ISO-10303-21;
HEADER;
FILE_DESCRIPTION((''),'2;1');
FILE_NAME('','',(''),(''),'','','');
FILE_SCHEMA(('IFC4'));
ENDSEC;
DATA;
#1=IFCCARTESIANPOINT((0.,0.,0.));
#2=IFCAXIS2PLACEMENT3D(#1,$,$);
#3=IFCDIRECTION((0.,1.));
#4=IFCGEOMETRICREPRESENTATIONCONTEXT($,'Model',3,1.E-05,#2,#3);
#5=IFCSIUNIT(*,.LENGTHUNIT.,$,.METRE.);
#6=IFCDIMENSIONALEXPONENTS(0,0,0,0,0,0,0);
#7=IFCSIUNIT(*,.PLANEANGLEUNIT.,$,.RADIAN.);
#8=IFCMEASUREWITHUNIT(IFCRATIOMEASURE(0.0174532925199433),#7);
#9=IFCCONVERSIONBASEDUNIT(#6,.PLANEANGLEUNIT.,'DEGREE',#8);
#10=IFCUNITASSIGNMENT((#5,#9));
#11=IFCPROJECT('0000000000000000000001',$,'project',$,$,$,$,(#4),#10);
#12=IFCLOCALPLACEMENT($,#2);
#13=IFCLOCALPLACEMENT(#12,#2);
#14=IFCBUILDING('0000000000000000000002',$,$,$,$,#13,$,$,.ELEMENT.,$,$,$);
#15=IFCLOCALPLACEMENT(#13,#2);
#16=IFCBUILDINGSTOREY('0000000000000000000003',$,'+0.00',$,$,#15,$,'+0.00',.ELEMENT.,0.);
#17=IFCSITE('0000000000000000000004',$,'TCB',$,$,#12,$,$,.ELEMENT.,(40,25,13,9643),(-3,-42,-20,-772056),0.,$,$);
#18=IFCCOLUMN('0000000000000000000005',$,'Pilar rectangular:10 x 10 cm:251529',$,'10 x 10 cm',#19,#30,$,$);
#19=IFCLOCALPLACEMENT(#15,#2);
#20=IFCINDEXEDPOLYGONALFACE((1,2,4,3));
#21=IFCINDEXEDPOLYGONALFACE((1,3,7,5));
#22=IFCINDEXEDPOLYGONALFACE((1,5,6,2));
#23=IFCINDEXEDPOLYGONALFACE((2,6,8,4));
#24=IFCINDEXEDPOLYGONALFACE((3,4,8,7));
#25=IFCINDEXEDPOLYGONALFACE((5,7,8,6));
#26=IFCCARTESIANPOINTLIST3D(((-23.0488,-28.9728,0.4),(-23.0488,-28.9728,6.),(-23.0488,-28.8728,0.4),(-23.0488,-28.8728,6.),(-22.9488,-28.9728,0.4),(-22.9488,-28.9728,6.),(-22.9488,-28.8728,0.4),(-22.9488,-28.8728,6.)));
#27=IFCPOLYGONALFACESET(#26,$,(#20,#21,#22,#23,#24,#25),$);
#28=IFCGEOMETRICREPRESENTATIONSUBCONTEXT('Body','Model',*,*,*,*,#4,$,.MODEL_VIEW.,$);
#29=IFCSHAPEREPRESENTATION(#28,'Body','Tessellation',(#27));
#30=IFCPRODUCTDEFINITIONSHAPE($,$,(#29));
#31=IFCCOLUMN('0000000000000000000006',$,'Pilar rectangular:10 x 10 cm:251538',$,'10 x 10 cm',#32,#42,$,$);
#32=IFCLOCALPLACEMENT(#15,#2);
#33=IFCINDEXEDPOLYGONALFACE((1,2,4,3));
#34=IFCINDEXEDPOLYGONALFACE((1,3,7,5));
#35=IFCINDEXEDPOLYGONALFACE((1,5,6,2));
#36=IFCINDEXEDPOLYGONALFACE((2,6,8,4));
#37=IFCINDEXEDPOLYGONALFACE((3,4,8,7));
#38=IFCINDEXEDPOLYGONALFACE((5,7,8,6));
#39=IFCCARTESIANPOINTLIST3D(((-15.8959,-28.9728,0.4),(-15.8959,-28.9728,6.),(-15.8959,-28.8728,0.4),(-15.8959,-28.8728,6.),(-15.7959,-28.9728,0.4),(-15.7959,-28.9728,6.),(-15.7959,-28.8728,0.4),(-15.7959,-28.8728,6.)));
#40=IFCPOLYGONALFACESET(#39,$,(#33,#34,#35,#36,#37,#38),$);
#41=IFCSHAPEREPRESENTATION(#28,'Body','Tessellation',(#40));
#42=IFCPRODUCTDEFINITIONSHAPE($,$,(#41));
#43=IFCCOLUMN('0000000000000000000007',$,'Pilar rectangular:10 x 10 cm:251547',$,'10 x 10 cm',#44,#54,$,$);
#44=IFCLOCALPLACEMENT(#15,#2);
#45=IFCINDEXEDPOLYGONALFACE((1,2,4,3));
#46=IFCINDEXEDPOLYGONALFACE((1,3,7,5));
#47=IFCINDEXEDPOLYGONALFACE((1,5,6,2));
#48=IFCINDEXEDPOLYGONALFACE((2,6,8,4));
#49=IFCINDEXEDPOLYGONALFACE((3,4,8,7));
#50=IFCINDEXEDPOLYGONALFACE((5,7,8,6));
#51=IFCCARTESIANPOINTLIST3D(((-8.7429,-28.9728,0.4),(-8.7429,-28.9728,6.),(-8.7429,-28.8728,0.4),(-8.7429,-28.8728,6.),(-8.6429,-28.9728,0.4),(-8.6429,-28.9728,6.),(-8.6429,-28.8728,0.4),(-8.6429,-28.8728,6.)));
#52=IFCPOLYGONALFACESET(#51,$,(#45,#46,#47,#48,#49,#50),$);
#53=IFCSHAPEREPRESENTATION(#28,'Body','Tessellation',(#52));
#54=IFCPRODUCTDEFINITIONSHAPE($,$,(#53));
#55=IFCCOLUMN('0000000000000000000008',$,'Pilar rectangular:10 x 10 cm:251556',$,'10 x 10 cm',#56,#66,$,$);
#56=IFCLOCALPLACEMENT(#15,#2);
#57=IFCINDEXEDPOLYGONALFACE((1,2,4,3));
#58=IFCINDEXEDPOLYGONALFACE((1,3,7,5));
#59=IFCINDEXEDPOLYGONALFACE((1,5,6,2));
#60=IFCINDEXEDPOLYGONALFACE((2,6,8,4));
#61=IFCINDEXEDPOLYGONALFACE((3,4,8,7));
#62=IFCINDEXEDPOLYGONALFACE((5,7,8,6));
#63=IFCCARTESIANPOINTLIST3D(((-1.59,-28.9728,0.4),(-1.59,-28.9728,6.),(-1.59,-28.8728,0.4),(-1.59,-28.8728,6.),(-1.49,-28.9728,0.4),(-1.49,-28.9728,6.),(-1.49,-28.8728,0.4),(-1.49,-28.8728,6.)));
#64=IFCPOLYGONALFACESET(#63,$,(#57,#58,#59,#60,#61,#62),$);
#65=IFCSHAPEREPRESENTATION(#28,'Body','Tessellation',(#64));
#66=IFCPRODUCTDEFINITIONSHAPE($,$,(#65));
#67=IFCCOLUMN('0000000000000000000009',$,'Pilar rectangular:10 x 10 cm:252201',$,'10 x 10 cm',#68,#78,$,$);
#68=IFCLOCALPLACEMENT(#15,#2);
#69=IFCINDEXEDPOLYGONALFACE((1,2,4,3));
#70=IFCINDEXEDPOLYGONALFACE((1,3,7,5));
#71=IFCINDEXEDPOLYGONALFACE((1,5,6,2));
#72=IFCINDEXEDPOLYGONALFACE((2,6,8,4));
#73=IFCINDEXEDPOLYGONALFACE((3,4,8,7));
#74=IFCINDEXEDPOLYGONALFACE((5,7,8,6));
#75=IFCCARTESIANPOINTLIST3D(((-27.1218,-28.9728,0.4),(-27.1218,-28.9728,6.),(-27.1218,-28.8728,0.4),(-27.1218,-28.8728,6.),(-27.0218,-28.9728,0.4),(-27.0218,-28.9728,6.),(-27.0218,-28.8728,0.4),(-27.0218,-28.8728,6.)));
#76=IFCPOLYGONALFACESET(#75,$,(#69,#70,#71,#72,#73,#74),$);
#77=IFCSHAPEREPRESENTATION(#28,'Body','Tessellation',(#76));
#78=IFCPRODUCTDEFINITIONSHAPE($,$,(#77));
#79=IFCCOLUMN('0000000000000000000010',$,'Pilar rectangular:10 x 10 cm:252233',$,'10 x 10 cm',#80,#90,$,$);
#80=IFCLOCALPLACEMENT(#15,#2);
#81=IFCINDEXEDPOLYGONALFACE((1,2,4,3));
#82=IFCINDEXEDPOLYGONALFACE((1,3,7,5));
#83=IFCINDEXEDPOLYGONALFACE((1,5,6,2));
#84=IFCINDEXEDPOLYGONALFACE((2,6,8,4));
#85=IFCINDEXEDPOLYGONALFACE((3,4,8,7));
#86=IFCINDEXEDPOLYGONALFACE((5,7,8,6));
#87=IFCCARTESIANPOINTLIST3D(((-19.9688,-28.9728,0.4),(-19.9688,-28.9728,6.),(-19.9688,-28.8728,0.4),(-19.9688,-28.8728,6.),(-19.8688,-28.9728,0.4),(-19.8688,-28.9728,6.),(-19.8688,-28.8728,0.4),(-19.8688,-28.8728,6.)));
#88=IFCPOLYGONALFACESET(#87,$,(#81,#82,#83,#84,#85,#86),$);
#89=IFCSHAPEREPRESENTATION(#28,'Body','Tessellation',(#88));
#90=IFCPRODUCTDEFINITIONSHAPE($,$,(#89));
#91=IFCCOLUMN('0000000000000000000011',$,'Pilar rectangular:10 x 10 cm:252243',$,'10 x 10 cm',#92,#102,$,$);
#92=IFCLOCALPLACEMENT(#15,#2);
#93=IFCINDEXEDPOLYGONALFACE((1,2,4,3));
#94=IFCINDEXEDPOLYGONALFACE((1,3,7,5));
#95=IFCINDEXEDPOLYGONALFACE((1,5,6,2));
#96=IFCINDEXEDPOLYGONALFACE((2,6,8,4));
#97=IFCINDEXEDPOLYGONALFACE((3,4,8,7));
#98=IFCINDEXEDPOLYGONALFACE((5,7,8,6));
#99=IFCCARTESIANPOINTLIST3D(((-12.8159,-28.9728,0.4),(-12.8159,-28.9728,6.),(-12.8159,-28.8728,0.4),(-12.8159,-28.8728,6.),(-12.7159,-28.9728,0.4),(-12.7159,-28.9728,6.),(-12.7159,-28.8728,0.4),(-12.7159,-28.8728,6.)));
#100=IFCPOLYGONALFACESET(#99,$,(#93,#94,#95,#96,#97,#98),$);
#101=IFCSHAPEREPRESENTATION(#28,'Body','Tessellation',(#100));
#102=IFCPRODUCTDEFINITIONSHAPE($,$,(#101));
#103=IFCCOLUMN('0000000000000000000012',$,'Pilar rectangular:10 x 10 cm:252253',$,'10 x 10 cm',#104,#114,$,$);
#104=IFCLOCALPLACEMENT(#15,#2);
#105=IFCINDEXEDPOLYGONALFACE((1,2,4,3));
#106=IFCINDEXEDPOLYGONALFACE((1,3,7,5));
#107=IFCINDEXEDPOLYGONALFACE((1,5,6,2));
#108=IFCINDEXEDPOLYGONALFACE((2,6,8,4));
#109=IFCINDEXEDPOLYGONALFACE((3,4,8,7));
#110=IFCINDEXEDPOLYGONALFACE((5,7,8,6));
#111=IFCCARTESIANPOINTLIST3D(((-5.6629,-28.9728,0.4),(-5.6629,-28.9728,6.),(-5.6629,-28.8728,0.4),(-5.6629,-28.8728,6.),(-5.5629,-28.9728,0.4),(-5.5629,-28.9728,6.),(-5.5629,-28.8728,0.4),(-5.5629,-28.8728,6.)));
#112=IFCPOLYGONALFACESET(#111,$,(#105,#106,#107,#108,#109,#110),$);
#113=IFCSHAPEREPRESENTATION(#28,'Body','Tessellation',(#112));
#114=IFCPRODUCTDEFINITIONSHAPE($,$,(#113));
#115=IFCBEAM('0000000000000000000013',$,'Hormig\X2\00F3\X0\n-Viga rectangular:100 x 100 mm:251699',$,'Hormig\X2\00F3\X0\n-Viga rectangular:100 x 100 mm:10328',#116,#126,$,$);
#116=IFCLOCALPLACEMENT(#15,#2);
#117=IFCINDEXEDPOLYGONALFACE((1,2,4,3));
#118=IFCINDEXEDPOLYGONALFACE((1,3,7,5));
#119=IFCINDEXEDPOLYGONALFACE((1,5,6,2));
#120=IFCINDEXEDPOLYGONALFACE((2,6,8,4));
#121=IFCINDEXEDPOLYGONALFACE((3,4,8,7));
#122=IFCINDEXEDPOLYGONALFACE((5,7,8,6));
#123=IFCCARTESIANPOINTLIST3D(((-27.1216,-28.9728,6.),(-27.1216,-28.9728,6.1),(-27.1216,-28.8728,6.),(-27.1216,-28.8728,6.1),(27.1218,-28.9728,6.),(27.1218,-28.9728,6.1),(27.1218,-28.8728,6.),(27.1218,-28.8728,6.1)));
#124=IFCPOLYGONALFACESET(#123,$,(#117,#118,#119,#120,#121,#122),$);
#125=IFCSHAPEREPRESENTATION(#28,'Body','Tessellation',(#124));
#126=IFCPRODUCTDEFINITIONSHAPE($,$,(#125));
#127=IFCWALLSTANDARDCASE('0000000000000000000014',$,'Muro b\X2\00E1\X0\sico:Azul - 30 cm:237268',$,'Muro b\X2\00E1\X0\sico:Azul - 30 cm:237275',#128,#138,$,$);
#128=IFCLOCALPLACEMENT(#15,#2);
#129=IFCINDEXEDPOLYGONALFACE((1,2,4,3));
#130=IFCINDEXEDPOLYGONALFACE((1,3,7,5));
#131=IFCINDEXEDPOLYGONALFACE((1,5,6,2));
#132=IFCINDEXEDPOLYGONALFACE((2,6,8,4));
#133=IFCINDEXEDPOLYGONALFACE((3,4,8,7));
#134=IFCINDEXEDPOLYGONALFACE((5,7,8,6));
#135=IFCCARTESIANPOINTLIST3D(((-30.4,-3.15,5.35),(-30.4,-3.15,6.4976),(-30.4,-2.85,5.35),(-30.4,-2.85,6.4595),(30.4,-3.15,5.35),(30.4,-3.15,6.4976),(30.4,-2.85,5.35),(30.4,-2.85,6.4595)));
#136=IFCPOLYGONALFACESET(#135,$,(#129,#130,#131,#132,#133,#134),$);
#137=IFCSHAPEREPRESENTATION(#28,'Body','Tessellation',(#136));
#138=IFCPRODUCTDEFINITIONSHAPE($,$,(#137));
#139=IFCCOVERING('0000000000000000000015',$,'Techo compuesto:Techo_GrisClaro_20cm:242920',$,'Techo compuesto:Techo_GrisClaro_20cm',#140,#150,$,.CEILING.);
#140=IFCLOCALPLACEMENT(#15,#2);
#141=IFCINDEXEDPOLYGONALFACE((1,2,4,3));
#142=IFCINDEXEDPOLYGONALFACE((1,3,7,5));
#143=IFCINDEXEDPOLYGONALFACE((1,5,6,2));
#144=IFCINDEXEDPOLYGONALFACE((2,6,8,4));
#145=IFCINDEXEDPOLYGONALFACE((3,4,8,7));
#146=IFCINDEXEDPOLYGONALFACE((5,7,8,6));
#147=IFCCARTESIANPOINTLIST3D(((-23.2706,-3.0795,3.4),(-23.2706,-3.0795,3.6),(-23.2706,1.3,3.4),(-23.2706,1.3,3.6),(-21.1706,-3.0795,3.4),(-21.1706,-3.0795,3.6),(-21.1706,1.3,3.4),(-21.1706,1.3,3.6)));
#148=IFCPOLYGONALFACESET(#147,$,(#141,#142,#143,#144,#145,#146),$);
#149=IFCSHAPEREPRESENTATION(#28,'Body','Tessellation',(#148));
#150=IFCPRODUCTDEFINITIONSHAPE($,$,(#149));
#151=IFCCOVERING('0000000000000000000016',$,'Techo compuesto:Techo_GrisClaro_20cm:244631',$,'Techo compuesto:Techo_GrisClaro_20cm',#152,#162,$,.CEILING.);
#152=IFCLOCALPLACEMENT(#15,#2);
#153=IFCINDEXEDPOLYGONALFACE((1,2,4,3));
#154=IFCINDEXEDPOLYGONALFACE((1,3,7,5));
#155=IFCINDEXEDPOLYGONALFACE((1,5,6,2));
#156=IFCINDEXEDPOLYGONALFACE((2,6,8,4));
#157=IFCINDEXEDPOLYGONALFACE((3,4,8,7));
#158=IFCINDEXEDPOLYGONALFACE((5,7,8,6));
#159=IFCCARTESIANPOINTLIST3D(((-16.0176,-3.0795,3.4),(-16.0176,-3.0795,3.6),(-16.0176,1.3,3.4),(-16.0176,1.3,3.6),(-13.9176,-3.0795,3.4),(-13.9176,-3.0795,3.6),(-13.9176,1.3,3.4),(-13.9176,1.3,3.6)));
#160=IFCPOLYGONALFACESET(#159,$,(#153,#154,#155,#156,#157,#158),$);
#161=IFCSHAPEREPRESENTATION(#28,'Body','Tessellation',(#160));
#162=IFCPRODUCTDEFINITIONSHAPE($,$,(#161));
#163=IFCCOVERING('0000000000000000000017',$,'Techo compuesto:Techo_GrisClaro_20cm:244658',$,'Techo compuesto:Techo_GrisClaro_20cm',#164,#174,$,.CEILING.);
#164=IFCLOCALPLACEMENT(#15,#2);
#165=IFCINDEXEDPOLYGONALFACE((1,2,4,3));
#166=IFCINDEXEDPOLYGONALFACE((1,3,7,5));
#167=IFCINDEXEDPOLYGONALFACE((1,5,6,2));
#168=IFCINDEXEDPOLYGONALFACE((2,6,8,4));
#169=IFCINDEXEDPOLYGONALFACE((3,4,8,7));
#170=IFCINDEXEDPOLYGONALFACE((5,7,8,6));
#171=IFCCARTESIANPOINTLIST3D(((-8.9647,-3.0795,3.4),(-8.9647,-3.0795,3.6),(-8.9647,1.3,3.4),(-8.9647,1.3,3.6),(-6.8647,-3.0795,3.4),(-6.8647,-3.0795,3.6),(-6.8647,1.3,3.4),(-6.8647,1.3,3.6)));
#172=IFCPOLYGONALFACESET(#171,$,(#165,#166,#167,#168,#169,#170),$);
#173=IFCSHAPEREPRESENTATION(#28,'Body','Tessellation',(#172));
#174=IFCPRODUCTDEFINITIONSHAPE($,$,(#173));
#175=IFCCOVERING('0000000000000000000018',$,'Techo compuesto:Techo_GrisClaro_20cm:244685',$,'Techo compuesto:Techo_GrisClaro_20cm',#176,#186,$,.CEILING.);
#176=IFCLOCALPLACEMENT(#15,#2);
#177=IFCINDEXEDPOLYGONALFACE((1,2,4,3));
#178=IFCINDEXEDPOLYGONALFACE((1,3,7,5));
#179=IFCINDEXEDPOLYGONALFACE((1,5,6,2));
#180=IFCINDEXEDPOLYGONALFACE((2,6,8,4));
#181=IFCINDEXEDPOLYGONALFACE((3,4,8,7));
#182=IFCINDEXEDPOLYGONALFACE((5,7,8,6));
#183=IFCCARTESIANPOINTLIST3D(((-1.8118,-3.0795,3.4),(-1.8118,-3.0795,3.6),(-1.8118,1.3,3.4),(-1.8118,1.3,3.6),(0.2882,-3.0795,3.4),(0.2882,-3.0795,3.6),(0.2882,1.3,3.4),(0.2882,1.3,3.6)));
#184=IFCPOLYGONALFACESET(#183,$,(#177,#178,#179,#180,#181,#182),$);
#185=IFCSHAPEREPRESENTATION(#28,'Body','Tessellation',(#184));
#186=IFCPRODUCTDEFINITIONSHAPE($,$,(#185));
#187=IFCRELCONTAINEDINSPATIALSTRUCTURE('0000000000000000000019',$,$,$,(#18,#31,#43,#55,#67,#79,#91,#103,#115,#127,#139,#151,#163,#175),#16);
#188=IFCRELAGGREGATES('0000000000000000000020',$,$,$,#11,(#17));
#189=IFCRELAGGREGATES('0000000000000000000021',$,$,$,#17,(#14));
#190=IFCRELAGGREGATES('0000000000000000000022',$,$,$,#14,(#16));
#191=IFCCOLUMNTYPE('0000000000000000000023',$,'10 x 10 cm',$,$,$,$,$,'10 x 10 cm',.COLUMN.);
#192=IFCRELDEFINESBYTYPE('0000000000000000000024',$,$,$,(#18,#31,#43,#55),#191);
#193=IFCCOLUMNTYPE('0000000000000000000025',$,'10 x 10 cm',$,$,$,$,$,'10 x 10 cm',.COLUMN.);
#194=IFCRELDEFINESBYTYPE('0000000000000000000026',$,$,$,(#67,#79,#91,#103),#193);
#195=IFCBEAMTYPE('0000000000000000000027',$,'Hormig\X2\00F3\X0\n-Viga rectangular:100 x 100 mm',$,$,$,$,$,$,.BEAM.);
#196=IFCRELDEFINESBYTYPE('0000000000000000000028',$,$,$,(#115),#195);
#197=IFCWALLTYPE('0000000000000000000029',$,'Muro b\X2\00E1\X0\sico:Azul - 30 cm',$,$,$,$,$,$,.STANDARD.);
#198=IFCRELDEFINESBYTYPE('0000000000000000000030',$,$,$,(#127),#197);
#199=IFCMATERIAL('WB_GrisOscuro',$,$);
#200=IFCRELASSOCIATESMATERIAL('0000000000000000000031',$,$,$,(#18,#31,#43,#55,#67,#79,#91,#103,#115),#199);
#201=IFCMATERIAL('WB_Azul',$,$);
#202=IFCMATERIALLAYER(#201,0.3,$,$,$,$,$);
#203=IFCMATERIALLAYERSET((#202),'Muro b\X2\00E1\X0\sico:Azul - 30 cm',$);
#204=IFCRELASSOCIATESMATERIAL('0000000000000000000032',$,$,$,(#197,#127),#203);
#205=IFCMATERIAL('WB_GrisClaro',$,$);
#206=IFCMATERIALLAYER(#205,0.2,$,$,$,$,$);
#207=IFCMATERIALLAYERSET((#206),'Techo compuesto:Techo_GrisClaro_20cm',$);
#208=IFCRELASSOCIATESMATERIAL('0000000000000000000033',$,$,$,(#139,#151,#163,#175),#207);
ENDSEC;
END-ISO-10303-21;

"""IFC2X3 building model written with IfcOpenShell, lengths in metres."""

from ifc_helpers import new_model, entity, si_unit, converted_unit, direction, frame, frame_2d, origin, origin_2d_with_axis, place, context, subcontext, project, spatial, polyline, rectangle, extrude, clip, bounded_halfspace, source, transform, mapped, material, layer, layer_set, layer_usage, type_object, type_shapes, element, save


model = new_model("IFC2X3")

# Units and contexts
model_context = context("Model", 3, precision=1e-05, world=origin(), true_north=direction((0.0, 1.0)))
body_context = subcontext(model_context, "Body", "Model", "MODEL_VIEW")
ifc_project = project(units=[si_unit("LENGTHUNIT", "METRE"), converted_unit("PLANEANGLEUNIT", "DEGREE", entity("IfcRatioMeasure", 0.0174532925199433), si_unit("PLANEANGLEUNIT", "RADIAN"), dimensions=[0, 0, 0, 0, 0, 0, 0])], contexts=[model_context])

# Site, building, storey
site_placement = place(None, origin())
site = spatial("IfcSite", under=ifc_project, at=site_placement, Name="TCB", CompositionType="ELEMENT", RefLatitude=(40, 25, 13, 9643), RefLongitude=(-3, -42, -20, -772056), RefElevation=0.0)
building_placement = place(site_placement, origin())
building = spatial("IfcBuilding", under=site, at=building_placement, CompositionType="ELEMENT")
storey_placement = place(building_placement, origin())
storey = spatial("IfcBuildingStorey", under=building, at=storey_placement, Name="+0.00", LongName="+0.00", CompositionType="ELEMENT", Elevation=0.0)

# Columns
ifc_material_1 = material(Name="WB_GrisOscuro")
column_type_1 = type_object("IfcColumnType", Name="10 x 10 cm", ElementType="10 x 10 cm", PredefinedType="COLUMN")
shared_shape_1 = source(origin(), body_context, "Body", "SweptSolid", [
    extrude(rectangle(XDim=0.1, YDim=0.1, at=origin_2d_with_axis()), frame((0.0, 0.0, 0.4), z_axis=(0.0, 0.0, 1.0), x_axis=(0.0, -1.0, 0.0)), (0.0, 0.0, 1.0), 5.6),
])
type_shapes(column_type_1, [shared_shape_1])
for number, where, name in (
    (1, (-22.9988, -28.9228, 0.0), "Pilar rectangular:10 x 10 cm:251529"),
    (2, (-15.8459, -28.9228, 0.0), "Pilar rectangular:10 x 10 cm:251538"),
    (3, (-8.6929, -28.9228, 0.0), "Pilar rectangular:10 x 10 cm:251547"),
    (4, (-1.54, -28.9228, 0.0), "Pilar rectangular:10 x 10 cm:251556"),
):
    element("IfcColumn", number, at=place(storey_placement, frame(where)), inside=storey, type_object=column_type_1, material=ifc_material_1, Name=name, ObjectType="10 x 10 cm", context=body_context, shape_type="MappedRepresentation", body=[
        mapped(shared_shape_1, transform((0.0, 0.0, 0.0), scale=1.0)),
    ])
column_type_2 = type_object("IfcColumnType", Name="10 x 10 cm", ElementType="10 x 10 cm", PredefinedType="COLUMN")
shared_shape_2 = source(origin(), body_context, "Body", "SweptSolid", [
    extrude(rectangle(XDim=0.1, YDim=0.1, at=origin_2d_with_axis()), frame((0.0, 0.0, 0.4), z_axis=(0.0, 0.0, 1.0), x_axis=(0.0, -1.0, 0.0)), (0.0, 0.0, 1.0), 5.6),
])
type_shapes(column_type_2, [shared_shape_2])
for number, where, z_axis, x_axis, name in (
    (5, (-27.0718, -28.9228, 0.0), (0.0, 0.0, 1.0), (-1.0, 0.0, 0.0), "Pilar rectangular:10 x 10 cm:252201"),
    (6, (-19.9188, -28.9228, 0.0), (0.0, 0.0, 1.0), (-1.0, 0.0, 0.0), "Pilar rectangular:10 x 10 cm:252233"),
    (7, (-12.7659, -28.9228, 0.0), (0.0, 0.0, 1.0), (-1.0, 0.0, 0.0), "Pilar rectangular:10 x 10 cm:252243"),
    (8, (-5.6129, -28.9228, 0.0), (0.0, 0.0, 1.0), (-1.0, 0.0, 0.0), "Pilar rectangular:10 x 10 cm:252253"),
):
    element("IfcColumn", number, at=place(storey_placement, frame(where, z_axis=z_axis, x_axis=x_axis)), inside=storey, type_object=column_type_2, material=ifc_material_1, Name=name, ObjectType="10 x 10 cm", context=body_context, shape_type="MappedRepresentation", body=[
        mapped(shared_shape_2, transform((0.0, 0.0, 0.0), scale=1.0)),
    ])

# Beam
beam_type = type_object("IfcBeamType", Name="Hormigón-Viga rectangular:100 x 100 mm", PredefinedType="BEAM")
beam_placement = place(storey_placement, frame((-27.1093, -28.9228, 6.0)))
element("IfcBeam", 9, at=beam_placement, inside=storey, type_object=beam_type, material=ifc_material_1, Name="Hormigón-Viga rectangular:100 x 100 mm:251699", ObjectType="Hormigón-Viga rectangular:100 x 100 mm:10328", context=body_context, shape_type="SweptSolid", body=[
    extrude(rectangle(XDim=0.1, YDim=0.1, at=frame_2d((0.0, 0.0), x_axis=(1.0, 0.0))), frame((-0.0123, 0.0, 0.05), z_axis=(1.0, 0.0, 0.0), x_axis=(0.0, 0.0, -1.0)), (0.0, 0.0, 1.0), 54.2434),
])

# Wall
ifc_material_2 = material(Name="WB_Azul")
ifc_layer_1 = layer(ifc_material_2, 0.3)
ifc_layer_set_1 = layer_set([ifc_layer_1], Name="Muro básico:Azul - 30 cm")
ifc_layer_usage_1 = layer_usage(ifc_layer_set_1, "AXIS2", "POSITIVE", -0.15)
wall_type = type_object("IfcWallType", Name="Muro básico:Azul - 30 cm", PredefinedType="STANDARD", material=ifc_layer_set_1)
wall_placement = place(storey_placement, frame((-30.4, -3.0, 5.35)))
element("IfcWallStandardCase", 10, at=wall_placement, inside=storey, type_object=wall_type, material=ifc_layer_usage_1, Name="Muro básico:Azul - 30 cm:237268", ObjectType="Muro básico:Azul - 30 cm:237275", context=body_context, shape_type="Clipping", body=[
    clip(extrude(rectangle(XDim=60.8, YDim=0.3, at=frame_2d((30.4, 0.0), x_axis=(-1.0, 0.0))), origin(), (0.0, 0.0, 1.0), 1.1476), bounded_halfspace(frame((0.0, -0.15, 1.1476), z_axis=(0.0, 0.125973, 0.992034), x_axis=(1.0, 0.0, 0.0)), False, frame((0.0, -0.15, 1.1476), z_axis=(0.0, 0.125973, 0.992034), x_axis=(1.0, 0.0, 0.0)), polyline([(0.0, 0.0), (60.8, 0.0), (60.8, 0.3024), (0.0, 0.3024), (0.0, 0.0)]))),
])

# Coverings
ifc_material_3 = material(Name="WB_GrisClaro")
ifc_layer_2 = layer(ifc_material_3, 0.2)
ifc_layer_set_2 = layer_set([ifc_layer_2], Name="Techo compuesto:Techo_GrisClaro_20cm")
ifc_layer_usage_2 = layer_usage(ifc_layer_set_2, "AXIS3", "POSITIVE", 0.0)
covering_1_placement = place(storey_placement, frame((-23.2706, -3.0795, 3.4)))
element("IfcCovering", 11, at=covering_1_placement, inside=storey, material=ifc_layer_usage_2, Name="Techo compuesto:Techo_GrisClaro_20cm:242920", ObjectType="Techo compuesto:Techo_GrisClaro_20cm", PredefinedType="CEILING", context=body_context, shape_type="SweptSolid", body=[
    extrude(rectangle(XDim=2.1, YDim=4.3795, at=frame_2d((0.0, 0.0), x_axis=(1.0, 0.0))), frame((1.05, 2.1897, 0.0), z_axis=(0.0, 0.0, 1.0), x_axis=(-1.0, 0.0, 0.0)), (0.0, 0.0, 1.0), 0.2),
])
ifc_layer_usage_3 = layer_usage(ifc_layer_set_2, "AXIS3", "POSITIVE", 0.0)
covering_2_placement = place(storey_placement, frame((-16.0176, -3.0795, 3.4)))
element("IfcCovering", 12, at=covering_2_placement, inside=storey, material=ifc_layer_usage_3, Name="Techo compuesto:Techo_GrisClaro_20cm:244631", ObjectType="Techo compuesto:Techo_GrisClaro_20cm", PredefinedType="CEILING", context=body_context, shape_type="SweptSolid", body=[
    extrude(rectangle(XDim=2.1, YDim=4.3795, at=frame_2d((0.0, 0.0), x_axis=(1.0, 0.0))), frame((1.05, 2.1897, 0.0), z_axis=(0.0, 0.0, 1.0), x_axis=(-1.0, 0.0, 0.0)), (0.0, 0.0, 1.0), 0.2),
])
ifc_layer_usage_4 = layer_usage(ifc_layer_set_2, "AXIS3", "POSITIVE", 0.0)
covering_3_placement = place(storey_placement, frame((-8.9647, -3.0795, 3.4)))
element("IfcCovering", 13, at=covering_3_placement, inside=storey, material=ifc_layer_usage_4, Name="Techo compuesto:Techo_GrisClaro_20cm:244658", ObjectType="Techo compuesto:Techo_GrisClaro_20cm", PredefinedType="CEILING", context=body_context, shape_type="SweptSolid", body=[
    extrude(rectangle(XDim=2.1, YDim=4.3795, at=origin_2d_with_axis()), frame((1.05, 2.1897, 0.0), z_axis=(0.0, 0.0, 1.0), x_axis=(-1.0, 0.0, 0.0)), (0.0, 0.0, 1.0), 0.2),
])
ifc_layer_usage_5 = layer_usage(ifc_layer_set_2, "AXIS3", "POSITIVE", 0.0)
covering_4_placement = place(storey_placement, frame((-1.8118, -3.0795, 3.4)))
element("IfcCovering", 14, at=covering_4_placement, inside=storey, material=ifc_layer_usage_5, Name="Techo compuesto:Techo_GrisClaro_20cm:244685", ObjectType="Techo compuesto:Techo_GrisClaro_20cm", PredefinedType="CEILING", context=body_context, shape_type="SweptSolid", body=[
    extrude(rectangle(XDim=2.1, YDim=4.3795, at=origin_2d_with_axis()), frame((1.05, 2.1897, 0.0), z_axis=(0.0, 0.0, 1.0), x_axis=(-1.0, 0.0, 0.0)), (0.0, 0.0, 1.0), 0.2),
])

save(model, "model.ifc")
